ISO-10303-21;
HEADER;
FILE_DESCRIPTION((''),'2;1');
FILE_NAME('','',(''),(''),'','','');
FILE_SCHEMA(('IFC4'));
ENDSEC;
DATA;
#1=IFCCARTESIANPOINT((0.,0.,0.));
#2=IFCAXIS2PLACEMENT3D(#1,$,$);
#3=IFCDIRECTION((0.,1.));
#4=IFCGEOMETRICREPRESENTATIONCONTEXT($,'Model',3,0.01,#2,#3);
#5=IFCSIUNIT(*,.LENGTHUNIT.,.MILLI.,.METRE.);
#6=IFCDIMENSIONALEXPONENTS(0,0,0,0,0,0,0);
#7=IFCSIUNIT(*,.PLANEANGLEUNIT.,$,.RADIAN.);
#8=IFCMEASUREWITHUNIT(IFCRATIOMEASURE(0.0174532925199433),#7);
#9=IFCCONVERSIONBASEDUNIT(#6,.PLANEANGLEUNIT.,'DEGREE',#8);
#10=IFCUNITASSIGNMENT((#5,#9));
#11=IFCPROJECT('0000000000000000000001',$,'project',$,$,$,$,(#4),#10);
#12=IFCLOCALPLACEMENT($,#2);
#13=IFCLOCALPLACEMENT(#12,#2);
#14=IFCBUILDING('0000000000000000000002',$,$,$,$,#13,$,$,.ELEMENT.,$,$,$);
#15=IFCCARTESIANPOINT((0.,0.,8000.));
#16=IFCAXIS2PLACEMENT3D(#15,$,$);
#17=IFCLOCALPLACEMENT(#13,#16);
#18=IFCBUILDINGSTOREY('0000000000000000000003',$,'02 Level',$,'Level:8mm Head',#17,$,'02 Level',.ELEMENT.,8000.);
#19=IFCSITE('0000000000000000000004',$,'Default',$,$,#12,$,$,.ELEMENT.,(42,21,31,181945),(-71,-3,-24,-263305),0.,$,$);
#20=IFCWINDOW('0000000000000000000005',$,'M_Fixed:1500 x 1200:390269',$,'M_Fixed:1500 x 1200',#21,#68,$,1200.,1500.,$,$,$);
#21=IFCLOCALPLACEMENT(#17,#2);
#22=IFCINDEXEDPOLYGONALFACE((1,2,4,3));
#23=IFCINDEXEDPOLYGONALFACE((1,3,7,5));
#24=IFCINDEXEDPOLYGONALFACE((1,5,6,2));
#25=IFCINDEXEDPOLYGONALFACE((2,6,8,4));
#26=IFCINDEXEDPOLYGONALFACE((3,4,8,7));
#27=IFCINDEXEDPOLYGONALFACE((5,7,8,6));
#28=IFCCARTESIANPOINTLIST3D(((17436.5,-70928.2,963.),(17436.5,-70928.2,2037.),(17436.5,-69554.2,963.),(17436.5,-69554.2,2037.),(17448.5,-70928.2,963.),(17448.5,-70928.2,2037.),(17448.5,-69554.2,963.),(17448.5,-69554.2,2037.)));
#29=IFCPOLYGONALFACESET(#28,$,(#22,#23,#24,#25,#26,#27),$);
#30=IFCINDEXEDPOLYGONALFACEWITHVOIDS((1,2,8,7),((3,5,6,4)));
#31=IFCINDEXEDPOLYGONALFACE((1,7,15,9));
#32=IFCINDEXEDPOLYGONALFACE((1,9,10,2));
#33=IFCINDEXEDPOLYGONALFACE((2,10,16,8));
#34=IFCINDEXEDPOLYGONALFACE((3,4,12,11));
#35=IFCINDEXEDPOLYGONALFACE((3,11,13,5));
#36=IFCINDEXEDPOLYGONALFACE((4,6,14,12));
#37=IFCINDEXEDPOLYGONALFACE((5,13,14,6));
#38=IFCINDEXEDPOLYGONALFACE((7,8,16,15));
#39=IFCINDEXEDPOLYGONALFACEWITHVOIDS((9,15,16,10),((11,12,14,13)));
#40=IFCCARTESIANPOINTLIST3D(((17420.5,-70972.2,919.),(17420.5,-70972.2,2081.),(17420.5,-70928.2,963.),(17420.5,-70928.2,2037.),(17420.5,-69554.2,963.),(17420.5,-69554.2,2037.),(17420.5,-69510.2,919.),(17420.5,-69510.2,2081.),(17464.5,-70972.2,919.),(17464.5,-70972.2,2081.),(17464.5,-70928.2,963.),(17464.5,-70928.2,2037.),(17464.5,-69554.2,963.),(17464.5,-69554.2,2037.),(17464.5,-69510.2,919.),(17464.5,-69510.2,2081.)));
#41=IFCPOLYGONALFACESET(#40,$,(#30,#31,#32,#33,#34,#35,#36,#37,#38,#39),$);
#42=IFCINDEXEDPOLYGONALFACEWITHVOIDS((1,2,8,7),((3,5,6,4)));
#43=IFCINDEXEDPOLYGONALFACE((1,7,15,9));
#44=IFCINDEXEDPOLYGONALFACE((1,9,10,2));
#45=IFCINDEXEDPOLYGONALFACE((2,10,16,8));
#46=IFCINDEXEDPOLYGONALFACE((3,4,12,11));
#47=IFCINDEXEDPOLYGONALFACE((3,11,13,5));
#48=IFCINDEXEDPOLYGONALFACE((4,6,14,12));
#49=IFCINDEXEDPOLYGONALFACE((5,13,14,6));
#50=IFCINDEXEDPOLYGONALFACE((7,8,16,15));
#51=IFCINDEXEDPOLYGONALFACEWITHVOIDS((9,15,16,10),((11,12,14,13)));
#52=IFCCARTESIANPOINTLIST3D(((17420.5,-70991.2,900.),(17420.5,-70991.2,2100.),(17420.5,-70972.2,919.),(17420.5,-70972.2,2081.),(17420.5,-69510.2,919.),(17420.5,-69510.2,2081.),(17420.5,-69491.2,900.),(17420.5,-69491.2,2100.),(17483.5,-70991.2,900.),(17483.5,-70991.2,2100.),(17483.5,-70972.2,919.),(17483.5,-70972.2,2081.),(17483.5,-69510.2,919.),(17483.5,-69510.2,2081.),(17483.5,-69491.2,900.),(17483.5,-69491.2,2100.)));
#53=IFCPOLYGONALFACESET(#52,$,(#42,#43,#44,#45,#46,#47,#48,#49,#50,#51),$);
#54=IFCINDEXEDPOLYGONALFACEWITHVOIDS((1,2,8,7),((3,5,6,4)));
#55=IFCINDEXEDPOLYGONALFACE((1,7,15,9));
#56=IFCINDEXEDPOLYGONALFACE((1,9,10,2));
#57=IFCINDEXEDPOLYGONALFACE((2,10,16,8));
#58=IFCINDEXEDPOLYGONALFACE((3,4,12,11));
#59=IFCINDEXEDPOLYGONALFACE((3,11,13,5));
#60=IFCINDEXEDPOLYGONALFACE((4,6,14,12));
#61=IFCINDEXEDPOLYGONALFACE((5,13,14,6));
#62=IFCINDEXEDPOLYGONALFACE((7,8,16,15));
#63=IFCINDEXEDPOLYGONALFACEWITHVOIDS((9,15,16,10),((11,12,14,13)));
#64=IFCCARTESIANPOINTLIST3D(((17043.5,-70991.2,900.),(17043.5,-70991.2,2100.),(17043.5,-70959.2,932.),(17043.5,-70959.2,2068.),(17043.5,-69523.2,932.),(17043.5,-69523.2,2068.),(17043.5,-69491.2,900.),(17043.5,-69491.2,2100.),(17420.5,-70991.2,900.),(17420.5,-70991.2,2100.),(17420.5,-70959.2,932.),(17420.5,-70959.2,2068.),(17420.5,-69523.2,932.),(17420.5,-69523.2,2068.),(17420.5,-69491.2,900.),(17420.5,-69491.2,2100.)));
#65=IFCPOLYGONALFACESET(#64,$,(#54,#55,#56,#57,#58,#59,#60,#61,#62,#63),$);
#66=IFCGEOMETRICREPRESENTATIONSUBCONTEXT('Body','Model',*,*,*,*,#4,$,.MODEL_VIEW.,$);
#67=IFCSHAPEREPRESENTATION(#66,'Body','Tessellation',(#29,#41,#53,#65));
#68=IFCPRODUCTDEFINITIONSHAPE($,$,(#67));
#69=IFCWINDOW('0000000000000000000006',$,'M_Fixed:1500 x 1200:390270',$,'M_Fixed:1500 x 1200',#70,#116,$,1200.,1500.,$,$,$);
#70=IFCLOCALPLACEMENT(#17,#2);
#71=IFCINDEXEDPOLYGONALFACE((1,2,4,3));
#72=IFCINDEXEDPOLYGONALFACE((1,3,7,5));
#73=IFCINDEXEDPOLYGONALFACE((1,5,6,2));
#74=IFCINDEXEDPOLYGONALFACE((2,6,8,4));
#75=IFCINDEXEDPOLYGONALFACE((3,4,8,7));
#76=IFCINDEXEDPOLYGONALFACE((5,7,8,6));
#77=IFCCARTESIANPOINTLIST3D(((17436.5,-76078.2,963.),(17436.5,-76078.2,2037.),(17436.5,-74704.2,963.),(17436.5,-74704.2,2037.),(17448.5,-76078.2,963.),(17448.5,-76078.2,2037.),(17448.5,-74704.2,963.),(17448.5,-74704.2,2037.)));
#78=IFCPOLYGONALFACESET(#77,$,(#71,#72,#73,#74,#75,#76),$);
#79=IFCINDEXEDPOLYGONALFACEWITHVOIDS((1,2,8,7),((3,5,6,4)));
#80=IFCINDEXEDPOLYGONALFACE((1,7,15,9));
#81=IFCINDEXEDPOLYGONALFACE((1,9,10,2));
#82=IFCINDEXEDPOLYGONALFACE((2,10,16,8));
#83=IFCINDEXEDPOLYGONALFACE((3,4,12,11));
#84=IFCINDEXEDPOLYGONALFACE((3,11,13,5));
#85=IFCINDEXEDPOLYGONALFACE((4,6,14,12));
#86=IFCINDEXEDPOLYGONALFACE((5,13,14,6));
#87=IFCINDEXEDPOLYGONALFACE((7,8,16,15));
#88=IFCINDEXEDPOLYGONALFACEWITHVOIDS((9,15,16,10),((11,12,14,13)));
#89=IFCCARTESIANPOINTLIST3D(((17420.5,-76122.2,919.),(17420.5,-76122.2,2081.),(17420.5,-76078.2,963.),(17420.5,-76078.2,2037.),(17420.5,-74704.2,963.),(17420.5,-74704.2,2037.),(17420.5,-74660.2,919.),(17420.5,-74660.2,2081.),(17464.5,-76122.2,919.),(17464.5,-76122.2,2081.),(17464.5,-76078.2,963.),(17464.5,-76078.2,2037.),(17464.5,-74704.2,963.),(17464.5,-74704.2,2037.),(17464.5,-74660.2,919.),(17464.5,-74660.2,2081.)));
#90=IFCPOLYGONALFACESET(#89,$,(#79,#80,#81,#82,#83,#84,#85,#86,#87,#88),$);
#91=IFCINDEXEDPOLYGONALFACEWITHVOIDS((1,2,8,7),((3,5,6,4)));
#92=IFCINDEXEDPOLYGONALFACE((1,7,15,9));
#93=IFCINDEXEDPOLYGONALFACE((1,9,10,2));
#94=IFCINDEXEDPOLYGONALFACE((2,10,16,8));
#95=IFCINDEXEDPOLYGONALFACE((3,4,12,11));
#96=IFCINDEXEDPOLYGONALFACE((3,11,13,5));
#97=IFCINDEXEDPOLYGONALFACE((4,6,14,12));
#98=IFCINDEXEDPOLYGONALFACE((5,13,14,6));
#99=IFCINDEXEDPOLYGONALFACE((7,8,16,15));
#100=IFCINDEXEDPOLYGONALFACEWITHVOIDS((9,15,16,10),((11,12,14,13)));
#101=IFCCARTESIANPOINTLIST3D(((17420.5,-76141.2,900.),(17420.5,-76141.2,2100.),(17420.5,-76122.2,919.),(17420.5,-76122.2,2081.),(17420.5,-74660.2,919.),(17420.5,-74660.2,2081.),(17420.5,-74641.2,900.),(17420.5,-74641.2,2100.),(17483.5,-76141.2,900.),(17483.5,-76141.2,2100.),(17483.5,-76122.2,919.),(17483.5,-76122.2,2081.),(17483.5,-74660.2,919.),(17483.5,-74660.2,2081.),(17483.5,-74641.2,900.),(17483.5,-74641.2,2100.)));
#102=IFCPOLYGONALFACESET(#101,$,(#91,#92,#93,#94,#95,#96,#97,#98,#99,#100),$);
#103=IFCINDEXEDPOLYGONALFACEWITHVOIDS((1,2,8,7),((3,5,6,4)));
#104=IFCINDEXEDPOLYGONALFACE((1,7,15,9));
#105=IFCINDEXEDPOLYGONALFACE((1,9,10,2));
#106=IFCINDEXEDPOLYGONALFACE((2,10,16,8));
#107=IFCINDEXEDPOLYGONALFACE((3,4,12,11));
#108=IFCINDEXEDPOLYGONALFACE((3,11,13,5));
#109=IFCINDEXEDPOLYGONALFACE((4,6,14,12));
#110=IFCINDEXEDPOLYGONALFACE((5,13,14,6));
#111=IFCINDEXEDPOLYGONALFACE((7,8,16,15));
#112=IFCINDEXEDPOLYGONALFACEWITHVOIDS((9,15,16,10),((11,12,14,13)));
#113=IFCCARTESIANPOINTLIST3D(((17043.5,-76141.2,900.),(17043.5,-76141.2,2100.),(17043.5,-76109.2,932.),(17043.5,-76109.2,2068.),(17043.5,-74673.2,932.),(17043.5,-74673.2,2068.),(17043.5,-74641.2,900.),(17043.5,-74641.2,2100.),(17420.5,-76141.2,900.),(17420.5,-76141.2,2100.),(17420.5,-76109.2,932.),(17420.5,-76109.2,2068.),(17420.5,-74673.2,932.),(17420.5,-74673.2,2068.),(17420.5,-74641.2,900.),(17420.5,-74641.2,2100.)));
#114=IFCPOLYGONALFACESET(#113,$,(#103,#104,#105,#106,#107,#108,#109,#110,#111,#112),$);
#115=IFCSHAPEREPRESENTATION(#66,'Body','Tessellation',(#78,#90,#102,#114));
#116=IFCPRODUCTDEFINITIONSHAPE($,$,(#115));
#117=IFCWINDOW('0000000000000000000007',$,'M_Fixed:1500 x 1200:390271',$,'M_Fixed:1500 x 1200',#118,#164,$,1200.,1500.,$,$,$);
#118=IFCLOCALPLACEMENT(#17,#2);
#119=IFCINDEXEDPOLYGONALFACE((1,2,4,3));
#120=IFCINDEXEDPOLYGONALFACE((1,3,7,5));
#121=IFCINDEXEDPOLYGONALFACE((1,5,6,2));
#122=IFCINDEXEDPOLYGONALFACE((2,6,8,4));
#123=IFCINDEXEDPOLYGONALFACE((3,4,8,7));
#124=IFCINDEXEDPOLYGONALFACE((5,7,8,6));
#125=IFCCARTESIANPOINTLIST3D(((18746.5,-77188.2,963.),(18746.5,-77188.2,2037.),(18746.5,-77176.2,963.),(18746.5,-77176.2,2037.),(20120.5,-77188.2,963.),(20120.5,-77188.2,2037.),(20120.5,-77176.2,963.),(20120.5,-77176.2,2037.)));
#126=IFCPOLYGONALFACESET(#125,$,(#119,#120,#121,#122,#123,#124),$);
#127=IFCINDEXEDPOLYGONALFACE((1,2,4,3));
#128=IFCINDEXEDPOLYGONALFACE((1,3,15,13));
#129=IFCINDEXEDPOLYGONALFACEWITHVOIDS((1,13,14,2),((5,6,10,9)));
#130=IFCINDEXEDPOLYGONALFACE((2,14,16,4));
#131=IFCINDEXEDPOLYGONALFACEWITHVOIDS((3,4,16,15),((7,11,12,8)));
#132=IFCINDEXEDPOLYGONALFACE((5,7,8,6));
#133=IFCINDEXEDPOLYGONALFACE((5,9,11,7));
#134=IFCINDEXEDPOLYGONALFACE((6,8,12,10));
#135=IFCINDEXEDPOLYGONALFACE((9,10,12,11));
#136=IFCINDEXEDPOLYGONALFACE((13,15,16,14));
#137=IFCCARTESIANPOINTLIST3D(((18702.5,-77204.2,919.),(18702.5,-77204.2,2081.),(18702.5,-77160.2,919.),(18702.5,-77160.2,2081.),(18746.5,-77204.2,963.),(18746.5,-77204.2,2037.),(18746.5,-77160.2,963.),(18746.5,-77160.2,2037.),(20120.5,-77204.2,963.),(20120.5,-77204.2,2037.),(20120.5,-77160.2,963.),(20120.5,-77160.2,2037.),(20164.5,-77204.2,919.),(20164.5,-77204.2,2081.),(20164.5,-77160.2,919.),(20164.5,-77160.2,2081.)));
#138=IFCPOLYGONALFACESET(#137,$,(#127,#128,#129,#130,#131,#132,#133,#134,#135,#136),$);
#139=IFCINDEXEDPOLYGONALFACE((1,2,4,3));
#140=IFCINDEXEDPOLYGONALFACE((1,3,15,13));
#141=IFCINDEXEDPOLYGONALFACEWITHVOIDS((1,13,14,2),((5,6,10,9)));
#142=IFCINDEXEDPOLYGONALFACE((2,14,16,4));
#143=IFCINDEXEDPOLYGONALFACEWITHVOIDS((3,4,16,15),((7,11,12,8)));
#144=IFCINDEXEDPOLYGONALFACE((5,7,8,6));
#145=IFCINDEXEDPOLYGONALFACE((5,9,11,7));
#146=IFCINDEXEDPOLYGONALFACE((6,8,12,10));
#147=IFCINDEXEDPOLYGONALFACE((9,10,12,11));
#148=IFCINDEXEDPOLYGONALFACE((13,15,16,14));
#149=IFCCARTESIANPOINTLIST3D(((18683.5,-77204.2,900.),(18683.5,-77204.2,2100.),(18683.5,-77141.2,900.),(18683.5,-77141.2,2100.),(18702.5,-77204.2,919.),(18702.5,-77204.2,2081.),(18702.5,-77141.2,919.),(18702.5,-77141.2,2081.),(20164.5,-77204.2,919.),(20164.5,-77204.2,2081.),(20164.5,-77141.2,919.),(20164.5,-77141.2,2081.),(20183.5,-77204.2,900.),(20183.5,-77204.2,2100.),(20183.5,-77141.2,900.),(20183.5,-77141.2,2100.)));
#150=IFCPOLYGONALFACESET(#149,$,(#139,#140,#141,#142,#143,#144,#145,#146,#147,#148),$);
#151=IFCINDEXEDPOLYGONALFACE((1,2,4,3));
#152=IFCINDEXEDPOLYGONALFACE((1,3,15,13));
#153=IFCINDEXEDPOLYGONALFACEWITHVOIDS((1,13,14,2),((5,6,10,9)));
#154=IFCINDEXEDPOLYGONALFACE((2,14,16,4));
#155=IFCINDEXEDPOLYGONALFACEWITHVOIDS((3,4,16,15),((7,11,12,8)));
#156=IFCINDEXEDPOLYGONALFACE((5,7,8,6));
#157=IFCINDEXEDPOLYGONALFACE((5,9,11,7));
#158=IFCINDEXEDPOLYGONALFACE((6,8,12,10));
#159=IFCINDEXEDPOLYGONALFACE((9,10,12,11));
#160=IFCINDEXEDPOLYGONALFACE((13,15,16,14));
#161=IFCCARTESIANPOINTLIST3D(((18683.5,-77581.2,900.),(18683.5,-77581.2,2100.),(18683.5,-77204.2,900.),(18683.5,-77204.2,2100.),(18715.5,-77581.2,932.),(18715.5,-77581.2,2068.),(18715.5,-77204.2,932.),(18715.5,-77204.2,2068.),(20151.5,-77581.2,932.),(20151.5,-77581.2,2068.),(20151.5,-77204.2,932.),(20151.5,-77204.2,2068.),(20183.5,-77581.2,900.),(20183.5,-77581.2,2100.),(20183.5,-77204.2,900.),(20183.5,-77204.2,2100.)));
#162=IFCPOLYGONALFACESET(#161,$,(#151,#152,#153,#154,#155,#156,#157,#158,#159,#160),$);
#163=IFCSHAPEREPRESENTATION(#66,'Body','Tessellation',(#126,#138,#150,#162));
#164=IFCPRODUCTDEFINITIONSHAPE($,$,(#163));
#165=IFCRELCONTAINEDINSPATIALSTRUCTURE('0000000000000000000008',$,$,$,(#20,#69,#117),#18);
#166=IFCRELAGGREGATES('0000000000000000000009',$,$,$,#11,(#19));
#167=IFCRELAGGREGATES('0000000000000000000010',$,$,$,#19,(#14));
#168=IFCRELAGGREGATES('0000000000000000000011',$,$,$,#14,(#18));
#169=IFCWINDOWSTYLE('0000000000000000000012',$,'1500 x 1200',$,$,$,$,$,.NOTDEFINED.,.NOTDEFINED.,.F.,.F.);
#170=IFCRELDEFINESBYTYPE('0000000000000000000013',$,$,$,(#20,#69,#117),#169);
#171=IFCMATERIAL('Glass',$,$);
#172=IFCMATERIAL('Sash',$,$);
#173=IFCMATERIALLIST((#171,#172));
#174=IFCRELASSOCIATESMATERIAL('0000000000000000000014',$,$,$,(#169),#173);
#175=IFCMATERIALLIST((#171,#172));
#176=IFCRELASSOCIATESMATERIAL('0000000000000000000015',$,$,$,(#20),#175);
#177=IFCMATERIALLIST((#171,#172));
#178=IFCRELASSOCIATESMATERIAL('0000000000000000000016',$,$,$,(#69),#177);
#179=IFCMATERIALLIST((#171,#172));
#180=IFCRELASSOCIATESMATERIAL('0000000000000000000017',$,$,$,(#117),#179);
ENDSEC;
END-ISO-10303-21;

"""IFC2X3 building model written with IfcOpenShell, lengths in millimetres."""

from ifc_helpers import new_model, entity, si_unit, converted_unit, direction, frame, origin, origin_2d_with_axis, place, context, subcontext, project, spatial, polyline, rectangle, outline, extrude, source, transform, mapped, material, material_list, type_object, type_shapes, element, save


model = new_model("IFC2X3")

# Units and contexts
model_context = context("Model", 3, precision=0.01, world=origin(), true_north=direction((0.0, 1.0)))
body_context = subcontext(model_context, "Body", "Model", "MODEL_VIEW")
ifc_project = project(units=[si_unit("LENGTHUNIT", "METRE", prefix="MILLI"), converted_unit("PLANEANGLEUNIT", "DEGREE", entity("IfcRatioMeasure", 0.0174532925199433), si_unit("PLANEANGLEUNIT", "RADIAN"), dimensions=[0, 0, 0, 0, 0, 0, 0])], contexts=[model_context])

# Site, building, storey
site_placement = place(None, origin())
site = spatial("IfcSite", under=ifc_project, at=site_placement, Name="Default", CompositionType="ELEMENT", RefLatitude=(42, 21, 31, 181945), RefLongitude=(-71, -3, -24, -263305), RefElevation=0.0)
building_placement = place(site_placement, origin())
building = spatial("IfcBuilding", under=site, at=building_placement, CompositionType="ELEMENT")
storey_placement = place(building_placement, frame((0.0, 0.0, 8000.0)))
storey = spatial("IfcBuildingStorey", under=building, at=storey_placement, Name="02 Level", ObjectType="Level:8mm Head", LongName="02 Level", CompositionType="ELEMENT", Elevation=8000.0)

# Windows
ifc_material_1 = material(Name="Glass")
ifc_material_2 = material(Name="Sash")
ifc_material_list_1 = material_list([ifc_material_1, ifc_material_2])
ifc_material_list_2 = material_list([ifc_material_1, ifc_material_2])
window_style_1 = type_object("IfcWindowStyle", Name="1500 x 1200", ConstructionType="NOTDEFINED", OperationType="NOTDEFINED", ParameterTakesPrecedence=False, Sizeable=False, material=ifc_material_list_2)
shared_shape_1 = source(origin(), body_context, "Body", "SweptSolid", [
    extrude(rectangle(XDim=12.0, YDim=1374.0, at=origin_2d_with_axis()), frame((750.0, 399.0, 63.0), z_axis=(0.0, 0.0, 1.0), x_axis=(0.0, -1.0, 0.0)), (0.0, 0.0, 1.0), 1074.0),
    extrude(outline(polyline([(-731.0, -581.0), (731.0, -581.0), (731.0, 581.0), (-731.0, 581.0), (-731.0, -581.0)]), holes=[polyline([(-687.0, -537.0), (-687.0, 537.0), (687.0, 537.0), (687.0, -537.0), (-687.0, -537.0)])]), frame((750.0, 377.0, 600.0), z_axis=(0.0, 1.0, 0.0), x_axis=(1.0, 0.0, 0.0)), (0.0, 0.0, 1.0), 44.0),
    extrude(outline(polyline([(-750.0, -600.0), (750.0, -600.0), (750.0, 600.0), (-750.0, 600.0), (-750.0, -600.0)]), holes=[polyline([(-731.0, -581.0), (-731.0, 581.0), (731.0, 581.0), (731.0, -581.0), (-731.0, -581.0)])]), frame((750.0, 377.0, 600.0), z_axis=(0.0, 1.0, 0.0), x_axis=(1.0, 0.0, 0.0)), (0.0, 0.0, 1.0), 63.0),
    extrude(outline(polyline([(-750.0, -600.0), (750.0, -600.0), (750.0, 600.0), (-750.0, 600.0), (-750.0, -600.0)]), holes=[polyline([(-718.0, -568.0), (-718.0, 568.0), (718.0, 568.0), (718.0, -568.0), (-718.0, -568.0)])]), frame((750.0, 0.0, 600.0), z_axis=(0.0, 1.0, 0.0), x_axis=(1.0, 0.0, 0.0)), (0.0, 0.0, 1.0), 377.0),
])
type_shapes(window_style_1, [shared_shape_1])
window_1_placement = place(storey_placement, frame((17043.5, -69491.2, 900.0), z_axis=(0.0, 0.0, 1.0), x_axis=(0.0, -1.0, 0.0)))
element("IfcWindow", 1, at=window_1_placement, inside=storey, type_object=window_style_1, material=ifc_material_list_1, Name="M_Fixed:1500 x 1200:390269", ObjectType="M_Fixed:1500 x 1200", OverallHeight=1200.0, OverallWidth=1500.0, context=body_context, shape_type="MappedRepresentation", body=[
    mapped(shared_shape_1, transform((0.0, 0.0, 0.0), scale=1.0)),
])
ifc_material_list_3 = material_list([ifc_material_1, ifc_material_2])
window_2_placement = place(storey_placement, frame((17043.5, -74641.2, 900.0), z_axis=(0.0, 0.0, 1.0), x_axis=(0.0, -1.0, 0.0)))
element("IfcWindow", 2, at=window_2_placement, inside=storey, type_object=window_style_1, material=ifc_material_list_3, Name="M_Fixed:1500 x 1200:390270", ObjectType="M_Fixed:1500 x 1200", OverallHeight=1200.0, OverallWidth=1500.0, context=body_context, shape_type="MappedRepresentation", body=[
    mapped(shared_shape_1, transform((0.0, 0.0, 0.0), scale=1.0)),
])
ifc_material_list_4 = material_list([ifc_material_1, ifc_material_2])
window_3_placement = place(storey_placement, frame((18683.5, -77581.2, 900.0)))
element("IfcWindow", 3, at=window_3_placement, inside=storey, type_object=window_style_1, material=ifc_material_list_4, Name="M_Fixed:1500 x 1200:390271", ObjectType="M_Fixed:1500 x 1200", OverallHeight=1200.0, OverallWidth=1500.0, context=body_context, shape_type="MappedRepresentation", body=[
    mapped(shared_shape_1, transform((0.0, 0.0, 0.0), scale=1.0)),
])

save(model, "model.ifc")
